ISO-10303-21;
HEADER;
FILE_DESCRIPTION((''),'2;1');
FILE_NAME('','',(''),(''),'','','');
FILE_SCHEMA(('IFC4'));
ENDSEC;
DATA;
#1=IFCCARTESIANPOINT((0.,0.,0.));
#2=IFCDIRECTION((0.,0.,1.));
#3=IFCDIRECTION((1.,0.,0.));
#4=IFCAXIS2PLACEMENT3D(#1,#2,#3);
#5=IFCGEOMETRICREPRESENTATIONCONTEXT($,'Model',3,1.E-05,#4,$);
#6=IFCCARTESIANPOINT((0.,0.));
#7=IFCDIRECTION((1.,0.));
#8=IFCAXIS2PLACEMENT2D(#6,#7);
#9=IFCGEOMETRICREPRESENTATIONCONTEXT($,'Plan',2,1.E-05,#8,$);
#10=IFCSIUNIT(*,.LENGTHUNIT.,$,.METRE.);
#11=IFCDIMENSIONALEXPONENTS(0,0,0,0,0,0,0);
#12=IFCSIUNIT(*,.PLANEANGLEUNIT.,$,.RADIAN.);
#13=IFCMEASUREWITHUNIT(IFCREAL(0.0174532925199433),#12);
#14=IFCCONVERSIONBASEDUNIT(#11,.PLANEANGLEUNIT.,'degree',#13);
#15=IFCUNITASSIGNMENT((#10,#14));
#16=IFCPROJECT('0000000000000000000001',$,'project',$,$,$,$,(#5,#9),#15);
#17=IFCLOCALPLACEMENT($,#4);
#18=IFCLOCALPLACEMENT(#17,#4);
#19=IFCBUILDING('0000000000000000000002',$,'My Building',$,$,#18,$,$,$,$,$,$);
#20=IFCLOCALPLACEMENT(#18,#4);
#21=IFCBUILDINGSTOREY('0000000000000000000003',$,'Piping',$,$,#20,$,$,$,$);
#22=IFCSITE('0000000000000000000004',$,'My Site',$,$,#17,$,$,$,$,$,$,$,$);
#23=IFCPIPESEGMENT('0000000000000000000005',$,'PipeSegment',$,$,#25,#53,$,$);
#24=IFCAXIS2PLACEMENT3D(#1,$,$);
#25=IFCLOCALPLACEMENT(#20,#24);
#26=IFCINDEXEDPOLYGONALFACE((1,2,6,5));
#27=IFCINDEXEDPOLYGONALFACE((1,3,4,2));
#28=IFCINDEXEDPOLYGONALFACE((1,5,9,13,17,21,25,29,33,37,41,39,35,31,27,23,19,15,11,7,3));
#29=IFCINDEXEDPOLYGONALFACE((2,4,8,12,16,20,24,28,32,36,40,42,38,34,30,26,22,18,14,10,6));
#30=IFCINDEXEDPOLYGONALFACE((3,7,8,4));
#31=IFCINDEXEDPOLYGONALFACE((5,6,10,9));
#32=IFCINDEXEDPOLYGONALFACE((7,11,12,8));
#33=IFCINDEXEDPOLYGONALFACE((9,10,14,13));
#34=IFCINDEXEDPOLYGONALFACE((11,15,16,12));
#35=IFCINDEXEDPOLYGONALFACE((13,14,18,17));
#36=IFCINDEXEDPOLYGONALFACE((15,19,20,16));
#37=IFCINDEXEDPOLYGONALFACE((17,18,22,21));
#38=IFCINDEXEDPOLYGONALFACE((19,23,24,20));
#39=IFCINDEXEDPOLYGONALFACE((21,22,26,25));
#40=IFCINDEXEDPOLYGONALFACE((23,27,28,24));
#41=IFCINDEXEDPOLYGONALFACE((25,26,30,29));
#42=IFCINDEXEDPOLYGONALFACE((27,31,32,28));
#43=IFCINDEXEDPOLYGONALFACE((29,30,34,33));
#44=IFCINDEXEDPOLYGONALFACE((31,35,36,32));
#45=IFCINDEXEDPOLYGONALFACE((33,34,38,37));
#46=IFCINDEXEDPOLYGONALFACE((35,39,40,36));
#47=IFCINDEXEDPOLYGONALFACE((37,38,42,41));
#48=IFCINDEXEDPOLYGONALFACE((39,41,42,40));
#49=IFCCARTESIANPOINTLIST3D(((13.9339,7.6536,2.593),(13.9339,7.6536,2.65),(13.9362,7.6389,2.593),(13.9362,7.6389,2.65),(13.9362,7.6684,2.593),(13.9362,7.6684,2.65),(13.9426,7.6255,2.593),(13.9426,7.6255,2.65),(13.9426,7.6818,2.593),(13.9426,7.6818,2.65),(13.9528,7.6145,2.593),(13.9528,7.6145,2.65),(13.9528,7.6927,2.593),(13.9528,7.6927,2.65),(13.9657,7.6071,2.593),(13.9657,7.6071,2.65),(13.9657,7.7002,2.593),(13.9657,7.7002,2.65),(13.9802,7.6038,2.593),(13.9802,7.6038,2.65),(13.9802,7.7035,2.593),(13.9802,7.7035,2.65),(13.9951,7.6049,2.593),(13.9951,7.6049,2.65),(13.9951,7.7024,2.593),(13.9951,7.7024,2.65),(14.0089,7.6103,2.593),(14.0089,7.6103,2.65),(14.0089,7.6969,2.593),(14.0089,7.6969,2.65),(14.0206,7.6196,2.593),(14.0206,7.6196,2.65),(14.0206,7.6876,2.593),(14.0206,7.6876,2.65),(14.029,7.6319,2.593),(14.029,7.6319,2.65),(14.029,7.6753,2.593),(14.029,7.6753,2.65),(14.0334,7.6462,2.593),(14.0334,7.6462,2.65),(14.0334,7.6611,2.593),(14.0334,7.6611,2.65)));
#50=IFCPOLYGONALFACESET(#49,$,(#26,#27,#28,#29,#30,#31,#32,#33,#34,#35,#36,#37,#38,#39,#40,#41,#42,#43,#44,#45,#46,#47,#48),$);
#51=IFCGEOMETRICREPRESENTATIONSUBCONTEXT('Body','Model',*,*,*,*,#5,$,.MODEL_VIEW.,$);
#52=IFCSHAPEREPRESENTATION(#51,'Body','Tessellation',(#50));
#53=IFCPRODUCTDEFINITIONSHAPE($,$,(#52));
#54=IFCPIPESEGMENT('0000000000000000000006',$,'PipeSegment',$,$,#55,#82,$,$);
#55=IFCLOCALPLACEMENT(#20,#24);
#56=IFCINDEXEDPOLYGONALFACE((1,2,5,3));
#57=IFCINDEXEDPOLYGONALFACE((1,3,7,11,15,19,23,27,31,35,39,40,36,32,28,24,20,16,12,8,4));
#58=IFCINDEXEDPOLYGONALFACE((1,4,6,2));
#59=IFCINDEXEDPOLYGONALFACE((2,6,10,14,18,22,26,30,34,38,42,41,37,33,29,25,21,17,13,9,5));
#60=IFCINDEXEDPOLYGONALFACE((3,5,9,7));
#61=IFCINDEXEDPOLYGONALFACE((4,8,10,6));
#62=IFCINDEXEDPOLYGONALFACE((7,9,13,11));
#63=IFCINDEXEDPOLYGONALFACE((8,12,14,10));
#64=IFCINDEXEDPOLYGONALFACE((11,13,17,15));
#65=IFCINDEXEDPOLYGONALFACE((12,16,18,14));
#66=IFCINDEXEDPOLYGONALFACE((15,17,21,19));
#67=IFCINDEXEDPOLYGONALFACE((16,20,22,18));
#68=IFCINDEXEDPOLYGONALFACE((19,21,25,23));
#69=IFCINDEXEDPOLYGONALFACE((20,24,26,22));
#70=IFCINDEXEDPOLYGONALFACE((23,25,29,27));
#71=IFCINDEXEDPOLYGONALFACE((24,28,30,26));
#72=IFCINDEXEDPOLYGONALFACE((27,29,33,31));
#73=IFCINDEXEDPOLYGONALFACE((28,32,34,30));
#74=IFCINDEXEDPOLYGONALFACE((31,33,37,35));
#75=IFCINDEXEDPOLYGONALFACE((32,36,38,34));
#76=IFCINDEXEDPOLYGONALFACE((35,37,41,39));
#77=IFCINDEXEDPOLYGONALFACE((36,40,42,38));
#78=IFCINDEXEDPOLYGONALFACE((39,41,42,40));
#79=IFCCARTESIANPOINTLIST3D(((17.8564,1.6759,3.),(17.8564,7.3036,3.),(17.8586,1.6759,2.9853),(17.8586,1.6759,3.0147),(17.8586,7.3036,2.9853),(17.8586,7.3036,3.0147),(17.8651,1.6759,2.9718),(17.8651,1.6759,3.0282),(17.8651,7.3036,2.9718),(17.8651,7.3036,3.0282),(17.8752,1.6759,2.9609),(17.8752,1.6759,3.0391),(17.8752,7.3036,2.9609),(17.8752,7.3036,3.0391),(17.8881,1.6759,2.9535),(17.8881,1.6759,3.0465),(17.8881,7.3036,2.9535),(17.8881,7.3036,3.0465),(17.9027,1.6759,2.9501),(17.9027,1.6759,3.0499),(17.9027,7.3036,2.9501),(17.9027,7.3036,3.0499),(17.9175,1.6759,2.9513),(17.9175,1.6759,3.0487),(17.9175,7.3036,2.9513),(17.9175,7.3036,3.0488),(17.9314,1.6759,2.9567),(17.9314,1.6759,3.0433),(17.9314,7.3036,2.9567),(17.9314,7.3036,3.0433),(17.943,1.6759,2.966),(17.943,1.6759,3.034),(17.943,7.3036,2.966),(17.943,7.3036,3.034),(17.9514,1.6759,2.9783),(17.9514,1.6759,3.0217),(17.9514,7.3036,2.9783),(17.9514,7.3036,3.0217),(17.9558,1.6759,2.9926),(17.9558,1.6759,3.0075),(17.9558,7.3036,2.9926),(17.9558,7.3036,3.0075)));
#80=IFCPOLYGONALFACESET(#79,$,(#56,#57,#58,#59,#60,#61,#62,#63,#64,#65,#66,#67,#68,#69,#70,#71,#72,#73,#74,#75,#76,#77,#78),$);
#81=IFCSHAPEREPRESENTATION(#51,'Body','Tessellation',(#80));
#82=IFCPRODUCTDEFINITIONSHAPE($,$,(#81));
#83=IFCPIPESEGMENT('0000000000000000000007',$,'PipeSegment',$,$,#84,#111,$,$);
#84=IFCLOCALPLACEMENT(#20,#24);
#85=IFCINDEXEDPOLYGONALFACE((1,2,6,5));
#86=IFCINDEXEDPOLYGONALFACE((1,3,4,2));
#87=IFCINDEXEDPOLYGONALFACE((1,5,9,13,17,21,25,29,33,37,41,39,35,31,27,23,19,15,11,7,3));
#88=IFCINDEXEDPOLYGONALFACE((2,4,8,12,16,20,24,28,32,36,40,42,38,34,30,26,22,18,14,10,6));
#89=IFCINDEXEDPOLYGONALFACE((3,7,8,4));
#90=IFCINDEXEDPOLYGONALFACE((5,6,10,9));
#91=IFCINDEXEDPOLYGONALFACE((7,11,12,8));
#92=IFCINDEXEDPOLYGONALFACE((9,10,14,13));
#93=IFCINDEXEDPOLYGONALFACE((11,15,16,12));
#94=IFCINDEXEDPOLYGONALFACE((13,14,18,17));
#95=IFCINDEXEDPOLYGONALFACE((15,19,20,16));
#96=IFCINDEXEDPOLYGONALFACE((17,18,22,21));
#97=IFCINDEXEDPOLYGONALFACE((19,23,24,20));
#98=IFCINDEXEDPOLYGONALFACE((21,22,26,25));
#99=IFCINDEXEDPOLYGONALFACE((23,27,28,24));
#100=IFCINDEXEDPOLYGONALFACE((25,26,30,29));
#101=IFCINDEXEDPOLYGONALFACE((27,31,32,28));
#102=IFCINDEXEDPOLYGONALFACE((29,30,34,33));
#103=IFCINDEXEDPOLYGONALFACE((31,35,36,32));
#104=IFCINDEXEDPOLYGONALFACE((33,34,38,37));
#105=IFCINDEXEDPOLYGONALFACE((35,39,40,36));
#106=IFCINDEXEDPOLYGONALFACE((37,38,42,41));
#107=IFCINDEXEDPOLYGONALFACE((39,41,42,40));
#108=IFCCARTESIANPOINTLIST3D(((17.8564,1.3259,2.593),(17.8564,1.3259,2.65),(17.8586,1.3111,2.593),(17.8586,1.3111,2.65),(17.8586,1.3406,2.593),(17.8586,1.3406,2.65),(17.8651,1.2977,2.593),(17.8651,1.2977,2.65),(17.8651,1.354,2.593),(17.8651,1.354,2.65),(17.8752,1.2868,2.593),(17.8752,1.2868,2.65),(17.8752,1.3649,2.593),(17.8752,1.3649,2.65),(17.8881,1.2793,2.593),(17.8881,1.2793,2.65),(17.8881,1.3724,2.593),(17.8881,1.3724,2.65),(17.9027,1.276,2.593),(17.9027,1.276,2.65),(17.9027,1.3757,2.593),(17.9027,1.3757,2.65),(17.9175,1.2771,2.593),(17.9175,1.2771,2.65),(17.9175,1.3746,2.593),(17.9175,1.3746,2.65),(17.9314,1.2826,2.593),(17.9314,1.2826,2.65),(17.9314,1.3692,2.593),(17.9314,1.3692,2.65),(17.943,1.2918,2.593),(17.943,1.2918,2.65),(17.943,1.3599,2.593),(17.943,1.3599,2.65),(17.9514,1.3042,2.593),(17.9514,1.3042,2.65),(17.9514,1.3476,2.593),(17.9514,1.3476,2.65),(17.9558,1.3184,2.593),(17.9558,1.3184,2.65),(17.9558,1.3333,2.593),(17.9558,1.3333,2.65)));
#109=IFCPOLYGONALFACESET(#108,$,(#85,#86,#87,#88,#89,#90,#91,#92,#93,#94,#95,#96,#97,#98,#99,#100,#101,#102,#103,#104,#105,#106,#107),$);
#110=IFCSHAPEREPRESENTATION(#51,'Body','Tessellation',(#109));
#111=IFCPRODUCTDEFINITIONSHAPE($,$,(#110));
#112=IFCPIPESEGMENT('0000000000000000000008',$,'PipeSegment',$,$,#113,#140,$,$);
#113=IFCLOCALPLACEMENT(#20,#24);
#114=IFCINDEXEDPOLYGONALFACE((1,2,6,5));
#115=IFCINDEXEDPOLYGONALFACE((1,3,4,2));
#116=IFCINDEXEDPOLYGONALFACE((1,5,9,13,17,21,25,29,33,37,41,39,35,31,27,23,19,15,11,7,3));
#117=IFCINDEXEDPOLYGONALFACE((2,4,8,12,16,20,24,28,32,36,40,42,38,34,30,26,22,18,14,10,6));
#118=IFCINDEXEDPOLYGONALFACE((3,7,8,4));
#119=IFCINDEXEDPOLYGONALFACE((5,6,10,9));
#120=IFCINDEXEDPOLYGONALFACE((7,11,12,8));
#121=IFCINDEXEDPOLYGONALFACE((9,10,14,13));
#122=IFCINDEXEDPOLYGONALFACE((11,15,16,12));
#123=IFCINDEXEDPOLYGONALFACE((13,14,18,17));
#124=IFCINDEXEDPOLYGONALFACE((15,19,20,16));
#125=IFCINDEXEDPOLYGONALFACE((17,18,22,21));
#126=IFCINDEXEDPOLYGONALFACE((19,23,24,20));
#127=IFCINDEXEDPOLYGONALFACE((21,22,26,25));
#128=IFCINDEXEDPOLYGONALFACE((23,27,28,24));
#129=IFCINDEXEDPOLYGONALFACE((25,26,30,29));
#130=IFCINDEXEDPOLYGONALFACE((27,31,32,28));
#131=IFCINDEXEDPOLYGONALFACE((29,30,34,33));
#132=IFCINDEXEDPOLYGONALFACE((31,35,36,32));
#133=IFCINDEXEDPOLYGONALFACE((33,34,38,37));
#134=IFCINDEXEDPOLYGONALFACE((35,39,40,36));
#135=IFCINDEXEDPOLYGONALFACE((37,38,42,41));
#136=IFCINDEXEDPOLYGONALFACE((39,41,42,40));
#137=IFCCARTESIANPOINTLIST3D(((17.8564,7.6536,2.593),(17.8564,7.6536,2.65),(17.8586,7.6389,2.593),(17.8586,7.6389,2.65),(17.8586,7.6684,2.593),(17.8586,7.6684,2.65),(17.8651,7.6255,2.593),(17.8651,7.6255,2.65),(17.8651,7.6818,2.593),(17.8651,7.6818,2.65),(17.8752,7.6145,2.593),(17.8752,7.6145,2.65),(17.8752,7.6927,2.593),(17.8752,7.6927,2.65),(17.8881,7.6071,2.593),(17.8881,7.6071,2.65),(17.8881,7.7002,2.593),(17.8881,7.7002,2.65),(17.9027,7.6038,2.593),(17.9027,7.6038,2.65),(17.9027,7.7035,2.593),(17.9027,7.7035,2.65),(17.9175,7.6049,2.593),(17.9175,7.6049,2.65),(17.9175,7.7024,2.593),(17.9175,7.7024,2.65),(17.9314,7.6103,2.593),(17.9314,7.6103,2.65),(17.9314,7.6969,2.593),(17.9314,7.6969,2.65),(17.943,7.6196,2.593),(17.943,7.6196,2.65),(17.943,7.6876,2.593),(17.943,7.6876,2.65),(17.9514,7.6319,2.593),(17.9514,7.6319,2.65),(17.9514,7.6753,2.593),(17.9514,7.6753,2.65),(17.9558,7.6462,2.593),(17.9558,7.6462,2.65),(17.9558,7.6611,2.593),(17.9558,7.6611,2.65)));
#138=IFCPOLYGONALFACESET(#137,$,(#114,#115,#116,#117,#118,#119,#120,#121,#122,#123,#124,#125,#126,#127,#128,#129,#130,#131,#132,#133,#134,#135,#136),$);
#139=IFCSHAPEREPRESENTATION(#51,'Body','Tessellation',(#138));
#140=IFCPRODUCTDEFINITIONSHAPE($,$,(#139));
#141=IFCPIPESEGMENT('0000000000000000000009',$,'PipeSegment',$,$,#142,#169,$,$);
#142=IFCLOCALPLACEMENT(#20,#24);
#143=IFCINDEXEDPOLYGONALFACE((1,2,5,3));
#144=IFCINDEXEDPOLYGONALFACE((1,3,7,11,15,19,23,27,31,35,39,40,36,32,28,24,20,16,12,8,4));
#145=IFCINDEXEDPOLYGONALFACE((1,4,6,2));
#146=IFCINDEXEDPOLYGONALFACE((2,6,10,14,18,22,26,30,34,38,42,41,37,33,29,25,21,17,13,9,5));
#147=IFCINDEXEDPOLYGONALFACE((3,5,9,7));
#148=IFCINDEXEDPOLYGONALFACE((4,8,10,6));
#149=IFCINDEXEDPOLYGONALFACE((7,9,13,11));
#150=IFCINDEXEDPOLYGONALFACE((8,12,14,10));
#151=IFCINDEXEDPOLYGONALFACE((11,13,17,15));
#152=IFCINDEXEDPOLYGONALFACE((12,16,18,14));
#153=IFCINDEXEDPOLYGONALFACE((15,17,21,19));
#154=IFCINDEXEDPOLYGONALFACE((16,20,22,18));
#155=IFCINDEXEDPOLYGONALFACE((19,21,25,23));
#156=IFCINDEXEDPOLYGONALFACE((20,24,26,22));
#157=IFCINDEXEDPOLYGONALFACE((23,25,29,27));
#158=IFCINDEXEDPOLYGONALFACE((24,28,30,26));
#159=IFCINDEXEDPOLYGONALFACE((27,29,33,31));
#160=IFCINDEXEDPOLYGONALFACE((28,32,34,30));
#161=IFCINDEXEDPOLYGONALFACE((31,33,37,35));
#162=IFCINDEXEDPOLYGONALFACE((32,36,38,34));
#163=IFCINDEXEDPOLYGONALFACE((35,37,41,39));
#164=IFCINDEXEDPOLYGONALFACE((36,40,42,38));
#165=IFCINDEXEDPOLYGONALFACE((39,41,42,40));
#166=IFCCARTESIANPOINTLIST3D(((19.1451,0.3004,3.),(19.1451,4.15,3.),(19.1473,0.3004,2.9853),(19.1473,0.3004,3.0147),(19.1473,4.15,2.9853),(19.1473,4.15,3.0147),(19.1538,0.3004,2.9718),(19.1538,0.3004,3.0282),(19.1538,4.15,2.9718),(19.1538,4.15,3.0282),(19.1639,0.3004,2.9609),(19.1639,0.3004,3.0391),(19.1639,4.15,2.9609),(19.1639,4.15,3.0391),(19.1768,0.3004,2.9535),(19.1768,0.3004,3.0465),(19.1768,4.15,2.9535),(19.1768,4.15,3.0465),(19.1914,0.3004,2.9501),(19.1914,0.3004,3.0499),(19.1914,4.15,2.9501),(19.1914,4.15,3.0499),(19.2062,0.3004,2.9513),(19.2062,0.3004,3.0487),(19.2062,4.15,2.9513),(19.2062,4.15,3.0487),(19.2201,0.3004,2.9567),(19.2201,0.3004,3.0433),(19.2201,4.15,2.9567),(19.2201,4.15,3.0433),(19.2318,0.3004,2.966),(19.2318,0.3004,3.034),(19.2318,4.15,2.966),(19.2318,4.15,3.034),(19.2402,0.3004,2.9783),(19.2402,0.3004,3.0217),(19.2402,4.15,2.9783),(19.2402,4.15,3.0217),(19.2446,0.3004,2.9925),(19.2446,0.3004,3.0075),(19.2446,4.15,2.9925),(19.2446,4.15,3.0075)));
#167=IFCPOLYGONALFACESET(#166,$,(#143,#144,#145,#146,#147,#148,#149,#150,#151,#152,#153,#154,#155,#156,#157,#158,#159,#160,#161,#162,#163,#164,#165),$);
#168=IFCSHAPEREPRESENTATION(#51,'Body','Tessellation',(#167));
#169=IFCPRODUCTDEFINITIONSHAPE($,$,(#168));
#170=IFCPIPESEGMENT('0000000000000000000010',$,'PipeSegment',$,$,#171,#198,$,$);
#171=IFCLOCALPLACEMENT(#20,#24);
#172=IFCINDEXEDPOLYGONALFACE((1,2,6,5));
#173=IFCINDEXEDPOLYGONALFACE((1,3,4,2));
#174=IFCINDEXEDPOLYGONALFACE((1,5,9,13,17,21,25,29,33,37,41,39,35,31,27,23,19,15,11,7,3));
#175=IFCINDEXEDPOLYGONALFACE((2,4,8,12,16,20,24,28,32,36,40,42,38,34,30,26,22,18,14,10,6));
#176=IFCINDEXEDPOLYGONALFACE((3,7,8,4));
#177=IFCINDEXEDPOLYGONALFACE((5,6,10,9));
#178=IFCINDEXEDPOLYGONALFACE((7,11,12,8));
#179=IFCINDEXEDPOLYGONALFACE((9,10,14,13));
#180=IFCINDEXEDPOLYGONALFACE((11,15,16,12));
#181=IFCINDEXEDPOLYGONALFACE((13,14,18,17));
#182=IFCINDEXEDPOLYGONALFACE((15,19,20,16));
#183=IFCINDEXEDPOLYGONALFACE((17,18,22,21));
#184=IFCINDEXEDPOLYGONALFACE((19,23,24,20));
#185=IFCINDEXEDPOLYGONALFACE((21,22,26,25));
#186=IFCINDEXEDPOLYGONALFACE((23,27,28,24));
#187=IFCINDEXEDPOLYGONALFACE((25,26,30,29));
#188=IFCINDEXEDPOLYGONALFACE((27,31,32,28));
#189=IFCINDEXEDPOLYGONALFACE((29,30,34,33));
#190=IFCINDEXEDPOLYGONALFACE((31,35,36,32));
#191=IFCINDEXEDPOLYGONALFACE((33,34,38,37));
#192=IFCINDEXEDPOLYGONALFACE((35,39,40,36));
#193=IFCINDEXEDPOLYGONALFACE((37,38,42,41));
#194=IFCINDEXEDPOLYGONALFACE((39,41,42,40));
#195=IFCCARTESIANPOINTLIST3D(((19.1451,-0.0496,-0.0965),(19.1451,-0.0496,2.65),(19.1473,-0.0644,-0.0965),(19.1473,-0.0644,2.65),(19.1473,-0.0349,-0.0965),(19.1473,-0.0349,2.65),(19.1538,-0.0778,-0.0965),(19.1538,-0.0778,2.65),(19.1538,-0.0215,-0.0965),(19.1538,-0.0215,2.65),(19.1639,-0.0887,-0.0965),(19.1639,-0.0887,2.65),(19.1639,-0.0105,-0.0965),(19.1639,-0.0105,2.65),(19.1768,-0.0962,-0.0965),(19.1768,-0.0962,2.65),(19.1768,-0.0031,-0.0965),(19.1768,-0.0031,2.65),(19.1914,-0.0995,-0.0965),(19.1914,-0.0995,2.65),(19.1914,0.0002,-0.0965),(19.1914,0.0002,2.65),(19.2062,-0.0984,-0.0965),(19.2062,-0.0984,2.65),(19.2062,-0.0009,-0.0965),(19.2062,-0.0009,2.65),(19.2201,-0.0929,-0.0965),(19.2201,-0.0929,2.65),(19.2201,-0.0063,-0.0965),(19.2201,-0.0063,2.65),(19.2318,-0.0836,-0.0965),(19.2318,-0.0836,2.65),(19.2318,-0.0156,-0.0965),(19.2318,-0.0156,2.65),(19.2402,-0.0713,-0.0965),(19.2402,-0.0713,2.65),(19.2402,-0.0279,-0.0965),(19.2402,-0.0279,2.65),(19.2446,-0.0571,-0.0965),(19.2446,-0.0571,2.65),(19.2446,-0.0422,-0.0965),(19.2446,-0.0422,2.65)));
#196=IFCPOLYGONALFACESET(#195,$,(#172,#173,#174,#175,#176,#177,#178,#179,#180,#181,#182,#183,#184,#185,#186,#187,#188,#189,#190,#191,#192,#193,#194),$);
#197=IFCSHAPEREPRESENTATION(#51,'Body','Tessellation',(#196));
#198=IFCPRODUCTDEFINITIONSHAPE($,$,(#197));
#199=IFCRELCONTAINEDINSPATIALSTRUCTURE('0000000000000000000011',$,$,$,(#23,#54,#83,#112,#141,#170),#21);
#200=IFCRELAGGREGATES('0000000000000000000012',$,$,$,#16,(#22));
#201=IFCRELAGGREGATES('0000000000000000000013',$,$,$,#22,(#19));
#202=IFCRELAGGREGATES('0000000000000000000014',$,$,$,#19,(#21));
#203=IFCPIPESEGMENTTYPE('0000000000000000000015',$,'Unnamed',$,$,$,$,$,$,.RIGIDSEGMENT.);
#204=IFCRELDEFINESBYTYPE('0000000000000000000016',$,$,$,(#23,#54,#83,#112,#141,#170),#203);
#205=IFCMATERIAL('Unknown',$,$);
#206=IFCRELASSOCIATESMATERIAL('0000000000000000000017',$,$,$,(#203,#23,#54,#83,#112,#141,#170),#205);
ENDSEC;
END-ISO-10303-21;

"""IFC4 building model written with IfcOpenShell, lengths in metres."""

from ifc_helpers import new_model, entity, si_unit, converted_unit, frame, origin_with_axes, origin_2d_with_axis, place, context, subcontext, project, spatial, circle, extrude, material, material_profile, profile_set, profile_usage, type_object, element, save


model = new_model("IFC4")

# Units and contexts
model_context = context("Model", 3, precision=1e-05, world=origin_with_axes())
plan_context = context("Plan", 2, precision=1e-05, world=origin_2d_with_axis())
body_context = subcontext(model_context, "Body", "Model", "MODEL_VIEW")
ifc_project = project(units=[si_unit("LENGTHUNIT", "METRE"), converted_unit("PLANEANGLEUNIT", "degree", entity("IfcReal", 0.0174532925199433), si_unit("PLANEANGLEUNIT", "RADIAN"), dimensions=[0, 0, 0, 0, 0, 0, 0])], contexts=[model_context, plan_context])

# Site, building, storey
site_placement = place(None, origin_with_axes())
site = spatial("IfcSite", under=ifc_project, at=site_placement, Name="My Site")
building_placement = place(site_placement, origin_with_axes())
building = spatial("IfcBuilding", under=site, at=building_placement, Name="My Building")
storey_placement = place(building_placement, origin_with_axes())
storey = spatial("IfcBuildingStorey", under=building, at=storey_placement, Name="Piping")

# Pipe segments
ifc_material = material(Name="Unknown")
ifc_material_profile = material_profile(ifc_material, circle(Radius=0.05))
ifc_profile_set = profile_set([ifc_material_profile])
pipe_segment_type = type_object("IfcPipeSegmentType", Name="Unnamed", PredefinedType="RIGIDSEGMENT", material=ifc_profile_set)
ifc_profile_usage_1 = profile_usage(ifc_profile_set, cardinal=5)
pipe_segment_1_placement = place(storey_placement, frame((13.9839, 7.6536, 2.65), z_axis=(0.0, 0.0, -1.0), x_axis=(-1.0, 0.0, 0.0)))
element("IfcPipeSegment", 1, at=pipe_segment_1_placement, inside=storey, type_object=pipe_segment_type, material=ifc_profile_usage_1, Name="PipeSegment", context=body_context, shape_type="SweptSolid", body=[
    extrude(circle(Radius=0.05), origin_with_axes(), (0.0, 0.0, 1.0), 0.057),
])
ifc_profile_usage_2 = profile_usage(ifc_profile_set, cardinal=5)
pipe_segment_2_placement = place(storey_placement, frame((17.9064, 1.6759, 3.0), z_axis=(0.0, 1.0, 0.0), x_axis=(-1.0, 0.0, 0.0)))
element("IfcPipeSegment", 2, at=pipe_segment_2_placement, inside=storey, type_object=pipe_segment_type, material=ifc_profile_usage_2, Name="PipeSegment", context=body_context, shape_type="SweptSolid", body=[
    extrude(circle(Radius=0.05), origin_with_axes(), (0.0, 0.0, 1.0), 5.6278),
])
ifc_profile_usage_3 = profile_usage(ifc_profile_set, cardinal=5)
pipe_segment_3_placement = place(storey_placement, frame((17.9064, 1.3259, 2.65), z_axis=(0.0, 0.0, -1.0), x_axis=(-1.0, 0.0, 0.0)))
element("IfcPipeSegment", 3, at=pipe_segment_3_placement, inside=storey, type_object=pipe_segment_type, material=ifc_profile_usage_3, Name="PipeSegment", context=body_context, shape_type="SweptSolid", body=[
    extrude(circle(Radius=0.05), origin_with_axes(), (0.0, 0.0, 1.0), 0.057),
])
ifc_profile_usage_4 = profile_usage(ifc_profile_set, cardinal=5)
pipe_segment_4_placement = place(storey_placement, frame((17.9064, 7.6536, 2.65), z_axis=(0.0, 0.0, -1.0), x_axis=(-1.0, 0.0, 0.0)))
element("IfcPipeSegment", 4, at=pipe_segment_4_placement, inside=storey, type_object=pipe_segment_type, material=ifc_profile_usage_4, Name="PipeSegment", context=body_context, shape_type="SweptSolid", body=[
    extrude(circle(Radius=0.05), origin_with_axes(), (0.0, 0.0, 1.0), 0.057),
])
ifc_profile_usage_5 = profile_usage(ifc_profile_set, cardinal=5)
pipe_segment_5_placement = place(storey_placement, frame((19.1951, 0.3004, 3.0), z_axis=(0.0, 1.0, 0.0), x_axis=(-1.0, 0.0, 0.0)))
element("IfcPipeSegment", 5, at=pipe_segment_5_placement, inside=storey, type_object=pipe_segment_type, material=ifc_profile_usage_5, Name="PipeSegment", context=body_context, shape_type="SweptSolid", body=[
    extrude(circle(Radius=0.05), origin_with_axes(), (0.0, 0.0, 1.0), 3.8496),
])
ifc_profile_usage_6 = profile_usage(ifc_profile_set, cardinal=5)
pipe_segment_6_placement = place(storey_placement, frame((19.1951, -0.0496, 2.65), z_axis=(0.0, 0.0, -1.0), x_axis=(-1.0, 0.0, 0.0)))
element("IfcPipeSegment", 6, at=pipe_segment_6_placement, inside=storey, type_object=pipe_segment_type, material=ifc_profile_usage_6, Name="PipeSegment", context=body_context, shape_type="SweptSolid", body=[
    extrude(circle(Radius=0.05), origin_with_axes(), (0.0, 0.0, 1.0), 2.7465),
])

save(model, "model.ifc")
